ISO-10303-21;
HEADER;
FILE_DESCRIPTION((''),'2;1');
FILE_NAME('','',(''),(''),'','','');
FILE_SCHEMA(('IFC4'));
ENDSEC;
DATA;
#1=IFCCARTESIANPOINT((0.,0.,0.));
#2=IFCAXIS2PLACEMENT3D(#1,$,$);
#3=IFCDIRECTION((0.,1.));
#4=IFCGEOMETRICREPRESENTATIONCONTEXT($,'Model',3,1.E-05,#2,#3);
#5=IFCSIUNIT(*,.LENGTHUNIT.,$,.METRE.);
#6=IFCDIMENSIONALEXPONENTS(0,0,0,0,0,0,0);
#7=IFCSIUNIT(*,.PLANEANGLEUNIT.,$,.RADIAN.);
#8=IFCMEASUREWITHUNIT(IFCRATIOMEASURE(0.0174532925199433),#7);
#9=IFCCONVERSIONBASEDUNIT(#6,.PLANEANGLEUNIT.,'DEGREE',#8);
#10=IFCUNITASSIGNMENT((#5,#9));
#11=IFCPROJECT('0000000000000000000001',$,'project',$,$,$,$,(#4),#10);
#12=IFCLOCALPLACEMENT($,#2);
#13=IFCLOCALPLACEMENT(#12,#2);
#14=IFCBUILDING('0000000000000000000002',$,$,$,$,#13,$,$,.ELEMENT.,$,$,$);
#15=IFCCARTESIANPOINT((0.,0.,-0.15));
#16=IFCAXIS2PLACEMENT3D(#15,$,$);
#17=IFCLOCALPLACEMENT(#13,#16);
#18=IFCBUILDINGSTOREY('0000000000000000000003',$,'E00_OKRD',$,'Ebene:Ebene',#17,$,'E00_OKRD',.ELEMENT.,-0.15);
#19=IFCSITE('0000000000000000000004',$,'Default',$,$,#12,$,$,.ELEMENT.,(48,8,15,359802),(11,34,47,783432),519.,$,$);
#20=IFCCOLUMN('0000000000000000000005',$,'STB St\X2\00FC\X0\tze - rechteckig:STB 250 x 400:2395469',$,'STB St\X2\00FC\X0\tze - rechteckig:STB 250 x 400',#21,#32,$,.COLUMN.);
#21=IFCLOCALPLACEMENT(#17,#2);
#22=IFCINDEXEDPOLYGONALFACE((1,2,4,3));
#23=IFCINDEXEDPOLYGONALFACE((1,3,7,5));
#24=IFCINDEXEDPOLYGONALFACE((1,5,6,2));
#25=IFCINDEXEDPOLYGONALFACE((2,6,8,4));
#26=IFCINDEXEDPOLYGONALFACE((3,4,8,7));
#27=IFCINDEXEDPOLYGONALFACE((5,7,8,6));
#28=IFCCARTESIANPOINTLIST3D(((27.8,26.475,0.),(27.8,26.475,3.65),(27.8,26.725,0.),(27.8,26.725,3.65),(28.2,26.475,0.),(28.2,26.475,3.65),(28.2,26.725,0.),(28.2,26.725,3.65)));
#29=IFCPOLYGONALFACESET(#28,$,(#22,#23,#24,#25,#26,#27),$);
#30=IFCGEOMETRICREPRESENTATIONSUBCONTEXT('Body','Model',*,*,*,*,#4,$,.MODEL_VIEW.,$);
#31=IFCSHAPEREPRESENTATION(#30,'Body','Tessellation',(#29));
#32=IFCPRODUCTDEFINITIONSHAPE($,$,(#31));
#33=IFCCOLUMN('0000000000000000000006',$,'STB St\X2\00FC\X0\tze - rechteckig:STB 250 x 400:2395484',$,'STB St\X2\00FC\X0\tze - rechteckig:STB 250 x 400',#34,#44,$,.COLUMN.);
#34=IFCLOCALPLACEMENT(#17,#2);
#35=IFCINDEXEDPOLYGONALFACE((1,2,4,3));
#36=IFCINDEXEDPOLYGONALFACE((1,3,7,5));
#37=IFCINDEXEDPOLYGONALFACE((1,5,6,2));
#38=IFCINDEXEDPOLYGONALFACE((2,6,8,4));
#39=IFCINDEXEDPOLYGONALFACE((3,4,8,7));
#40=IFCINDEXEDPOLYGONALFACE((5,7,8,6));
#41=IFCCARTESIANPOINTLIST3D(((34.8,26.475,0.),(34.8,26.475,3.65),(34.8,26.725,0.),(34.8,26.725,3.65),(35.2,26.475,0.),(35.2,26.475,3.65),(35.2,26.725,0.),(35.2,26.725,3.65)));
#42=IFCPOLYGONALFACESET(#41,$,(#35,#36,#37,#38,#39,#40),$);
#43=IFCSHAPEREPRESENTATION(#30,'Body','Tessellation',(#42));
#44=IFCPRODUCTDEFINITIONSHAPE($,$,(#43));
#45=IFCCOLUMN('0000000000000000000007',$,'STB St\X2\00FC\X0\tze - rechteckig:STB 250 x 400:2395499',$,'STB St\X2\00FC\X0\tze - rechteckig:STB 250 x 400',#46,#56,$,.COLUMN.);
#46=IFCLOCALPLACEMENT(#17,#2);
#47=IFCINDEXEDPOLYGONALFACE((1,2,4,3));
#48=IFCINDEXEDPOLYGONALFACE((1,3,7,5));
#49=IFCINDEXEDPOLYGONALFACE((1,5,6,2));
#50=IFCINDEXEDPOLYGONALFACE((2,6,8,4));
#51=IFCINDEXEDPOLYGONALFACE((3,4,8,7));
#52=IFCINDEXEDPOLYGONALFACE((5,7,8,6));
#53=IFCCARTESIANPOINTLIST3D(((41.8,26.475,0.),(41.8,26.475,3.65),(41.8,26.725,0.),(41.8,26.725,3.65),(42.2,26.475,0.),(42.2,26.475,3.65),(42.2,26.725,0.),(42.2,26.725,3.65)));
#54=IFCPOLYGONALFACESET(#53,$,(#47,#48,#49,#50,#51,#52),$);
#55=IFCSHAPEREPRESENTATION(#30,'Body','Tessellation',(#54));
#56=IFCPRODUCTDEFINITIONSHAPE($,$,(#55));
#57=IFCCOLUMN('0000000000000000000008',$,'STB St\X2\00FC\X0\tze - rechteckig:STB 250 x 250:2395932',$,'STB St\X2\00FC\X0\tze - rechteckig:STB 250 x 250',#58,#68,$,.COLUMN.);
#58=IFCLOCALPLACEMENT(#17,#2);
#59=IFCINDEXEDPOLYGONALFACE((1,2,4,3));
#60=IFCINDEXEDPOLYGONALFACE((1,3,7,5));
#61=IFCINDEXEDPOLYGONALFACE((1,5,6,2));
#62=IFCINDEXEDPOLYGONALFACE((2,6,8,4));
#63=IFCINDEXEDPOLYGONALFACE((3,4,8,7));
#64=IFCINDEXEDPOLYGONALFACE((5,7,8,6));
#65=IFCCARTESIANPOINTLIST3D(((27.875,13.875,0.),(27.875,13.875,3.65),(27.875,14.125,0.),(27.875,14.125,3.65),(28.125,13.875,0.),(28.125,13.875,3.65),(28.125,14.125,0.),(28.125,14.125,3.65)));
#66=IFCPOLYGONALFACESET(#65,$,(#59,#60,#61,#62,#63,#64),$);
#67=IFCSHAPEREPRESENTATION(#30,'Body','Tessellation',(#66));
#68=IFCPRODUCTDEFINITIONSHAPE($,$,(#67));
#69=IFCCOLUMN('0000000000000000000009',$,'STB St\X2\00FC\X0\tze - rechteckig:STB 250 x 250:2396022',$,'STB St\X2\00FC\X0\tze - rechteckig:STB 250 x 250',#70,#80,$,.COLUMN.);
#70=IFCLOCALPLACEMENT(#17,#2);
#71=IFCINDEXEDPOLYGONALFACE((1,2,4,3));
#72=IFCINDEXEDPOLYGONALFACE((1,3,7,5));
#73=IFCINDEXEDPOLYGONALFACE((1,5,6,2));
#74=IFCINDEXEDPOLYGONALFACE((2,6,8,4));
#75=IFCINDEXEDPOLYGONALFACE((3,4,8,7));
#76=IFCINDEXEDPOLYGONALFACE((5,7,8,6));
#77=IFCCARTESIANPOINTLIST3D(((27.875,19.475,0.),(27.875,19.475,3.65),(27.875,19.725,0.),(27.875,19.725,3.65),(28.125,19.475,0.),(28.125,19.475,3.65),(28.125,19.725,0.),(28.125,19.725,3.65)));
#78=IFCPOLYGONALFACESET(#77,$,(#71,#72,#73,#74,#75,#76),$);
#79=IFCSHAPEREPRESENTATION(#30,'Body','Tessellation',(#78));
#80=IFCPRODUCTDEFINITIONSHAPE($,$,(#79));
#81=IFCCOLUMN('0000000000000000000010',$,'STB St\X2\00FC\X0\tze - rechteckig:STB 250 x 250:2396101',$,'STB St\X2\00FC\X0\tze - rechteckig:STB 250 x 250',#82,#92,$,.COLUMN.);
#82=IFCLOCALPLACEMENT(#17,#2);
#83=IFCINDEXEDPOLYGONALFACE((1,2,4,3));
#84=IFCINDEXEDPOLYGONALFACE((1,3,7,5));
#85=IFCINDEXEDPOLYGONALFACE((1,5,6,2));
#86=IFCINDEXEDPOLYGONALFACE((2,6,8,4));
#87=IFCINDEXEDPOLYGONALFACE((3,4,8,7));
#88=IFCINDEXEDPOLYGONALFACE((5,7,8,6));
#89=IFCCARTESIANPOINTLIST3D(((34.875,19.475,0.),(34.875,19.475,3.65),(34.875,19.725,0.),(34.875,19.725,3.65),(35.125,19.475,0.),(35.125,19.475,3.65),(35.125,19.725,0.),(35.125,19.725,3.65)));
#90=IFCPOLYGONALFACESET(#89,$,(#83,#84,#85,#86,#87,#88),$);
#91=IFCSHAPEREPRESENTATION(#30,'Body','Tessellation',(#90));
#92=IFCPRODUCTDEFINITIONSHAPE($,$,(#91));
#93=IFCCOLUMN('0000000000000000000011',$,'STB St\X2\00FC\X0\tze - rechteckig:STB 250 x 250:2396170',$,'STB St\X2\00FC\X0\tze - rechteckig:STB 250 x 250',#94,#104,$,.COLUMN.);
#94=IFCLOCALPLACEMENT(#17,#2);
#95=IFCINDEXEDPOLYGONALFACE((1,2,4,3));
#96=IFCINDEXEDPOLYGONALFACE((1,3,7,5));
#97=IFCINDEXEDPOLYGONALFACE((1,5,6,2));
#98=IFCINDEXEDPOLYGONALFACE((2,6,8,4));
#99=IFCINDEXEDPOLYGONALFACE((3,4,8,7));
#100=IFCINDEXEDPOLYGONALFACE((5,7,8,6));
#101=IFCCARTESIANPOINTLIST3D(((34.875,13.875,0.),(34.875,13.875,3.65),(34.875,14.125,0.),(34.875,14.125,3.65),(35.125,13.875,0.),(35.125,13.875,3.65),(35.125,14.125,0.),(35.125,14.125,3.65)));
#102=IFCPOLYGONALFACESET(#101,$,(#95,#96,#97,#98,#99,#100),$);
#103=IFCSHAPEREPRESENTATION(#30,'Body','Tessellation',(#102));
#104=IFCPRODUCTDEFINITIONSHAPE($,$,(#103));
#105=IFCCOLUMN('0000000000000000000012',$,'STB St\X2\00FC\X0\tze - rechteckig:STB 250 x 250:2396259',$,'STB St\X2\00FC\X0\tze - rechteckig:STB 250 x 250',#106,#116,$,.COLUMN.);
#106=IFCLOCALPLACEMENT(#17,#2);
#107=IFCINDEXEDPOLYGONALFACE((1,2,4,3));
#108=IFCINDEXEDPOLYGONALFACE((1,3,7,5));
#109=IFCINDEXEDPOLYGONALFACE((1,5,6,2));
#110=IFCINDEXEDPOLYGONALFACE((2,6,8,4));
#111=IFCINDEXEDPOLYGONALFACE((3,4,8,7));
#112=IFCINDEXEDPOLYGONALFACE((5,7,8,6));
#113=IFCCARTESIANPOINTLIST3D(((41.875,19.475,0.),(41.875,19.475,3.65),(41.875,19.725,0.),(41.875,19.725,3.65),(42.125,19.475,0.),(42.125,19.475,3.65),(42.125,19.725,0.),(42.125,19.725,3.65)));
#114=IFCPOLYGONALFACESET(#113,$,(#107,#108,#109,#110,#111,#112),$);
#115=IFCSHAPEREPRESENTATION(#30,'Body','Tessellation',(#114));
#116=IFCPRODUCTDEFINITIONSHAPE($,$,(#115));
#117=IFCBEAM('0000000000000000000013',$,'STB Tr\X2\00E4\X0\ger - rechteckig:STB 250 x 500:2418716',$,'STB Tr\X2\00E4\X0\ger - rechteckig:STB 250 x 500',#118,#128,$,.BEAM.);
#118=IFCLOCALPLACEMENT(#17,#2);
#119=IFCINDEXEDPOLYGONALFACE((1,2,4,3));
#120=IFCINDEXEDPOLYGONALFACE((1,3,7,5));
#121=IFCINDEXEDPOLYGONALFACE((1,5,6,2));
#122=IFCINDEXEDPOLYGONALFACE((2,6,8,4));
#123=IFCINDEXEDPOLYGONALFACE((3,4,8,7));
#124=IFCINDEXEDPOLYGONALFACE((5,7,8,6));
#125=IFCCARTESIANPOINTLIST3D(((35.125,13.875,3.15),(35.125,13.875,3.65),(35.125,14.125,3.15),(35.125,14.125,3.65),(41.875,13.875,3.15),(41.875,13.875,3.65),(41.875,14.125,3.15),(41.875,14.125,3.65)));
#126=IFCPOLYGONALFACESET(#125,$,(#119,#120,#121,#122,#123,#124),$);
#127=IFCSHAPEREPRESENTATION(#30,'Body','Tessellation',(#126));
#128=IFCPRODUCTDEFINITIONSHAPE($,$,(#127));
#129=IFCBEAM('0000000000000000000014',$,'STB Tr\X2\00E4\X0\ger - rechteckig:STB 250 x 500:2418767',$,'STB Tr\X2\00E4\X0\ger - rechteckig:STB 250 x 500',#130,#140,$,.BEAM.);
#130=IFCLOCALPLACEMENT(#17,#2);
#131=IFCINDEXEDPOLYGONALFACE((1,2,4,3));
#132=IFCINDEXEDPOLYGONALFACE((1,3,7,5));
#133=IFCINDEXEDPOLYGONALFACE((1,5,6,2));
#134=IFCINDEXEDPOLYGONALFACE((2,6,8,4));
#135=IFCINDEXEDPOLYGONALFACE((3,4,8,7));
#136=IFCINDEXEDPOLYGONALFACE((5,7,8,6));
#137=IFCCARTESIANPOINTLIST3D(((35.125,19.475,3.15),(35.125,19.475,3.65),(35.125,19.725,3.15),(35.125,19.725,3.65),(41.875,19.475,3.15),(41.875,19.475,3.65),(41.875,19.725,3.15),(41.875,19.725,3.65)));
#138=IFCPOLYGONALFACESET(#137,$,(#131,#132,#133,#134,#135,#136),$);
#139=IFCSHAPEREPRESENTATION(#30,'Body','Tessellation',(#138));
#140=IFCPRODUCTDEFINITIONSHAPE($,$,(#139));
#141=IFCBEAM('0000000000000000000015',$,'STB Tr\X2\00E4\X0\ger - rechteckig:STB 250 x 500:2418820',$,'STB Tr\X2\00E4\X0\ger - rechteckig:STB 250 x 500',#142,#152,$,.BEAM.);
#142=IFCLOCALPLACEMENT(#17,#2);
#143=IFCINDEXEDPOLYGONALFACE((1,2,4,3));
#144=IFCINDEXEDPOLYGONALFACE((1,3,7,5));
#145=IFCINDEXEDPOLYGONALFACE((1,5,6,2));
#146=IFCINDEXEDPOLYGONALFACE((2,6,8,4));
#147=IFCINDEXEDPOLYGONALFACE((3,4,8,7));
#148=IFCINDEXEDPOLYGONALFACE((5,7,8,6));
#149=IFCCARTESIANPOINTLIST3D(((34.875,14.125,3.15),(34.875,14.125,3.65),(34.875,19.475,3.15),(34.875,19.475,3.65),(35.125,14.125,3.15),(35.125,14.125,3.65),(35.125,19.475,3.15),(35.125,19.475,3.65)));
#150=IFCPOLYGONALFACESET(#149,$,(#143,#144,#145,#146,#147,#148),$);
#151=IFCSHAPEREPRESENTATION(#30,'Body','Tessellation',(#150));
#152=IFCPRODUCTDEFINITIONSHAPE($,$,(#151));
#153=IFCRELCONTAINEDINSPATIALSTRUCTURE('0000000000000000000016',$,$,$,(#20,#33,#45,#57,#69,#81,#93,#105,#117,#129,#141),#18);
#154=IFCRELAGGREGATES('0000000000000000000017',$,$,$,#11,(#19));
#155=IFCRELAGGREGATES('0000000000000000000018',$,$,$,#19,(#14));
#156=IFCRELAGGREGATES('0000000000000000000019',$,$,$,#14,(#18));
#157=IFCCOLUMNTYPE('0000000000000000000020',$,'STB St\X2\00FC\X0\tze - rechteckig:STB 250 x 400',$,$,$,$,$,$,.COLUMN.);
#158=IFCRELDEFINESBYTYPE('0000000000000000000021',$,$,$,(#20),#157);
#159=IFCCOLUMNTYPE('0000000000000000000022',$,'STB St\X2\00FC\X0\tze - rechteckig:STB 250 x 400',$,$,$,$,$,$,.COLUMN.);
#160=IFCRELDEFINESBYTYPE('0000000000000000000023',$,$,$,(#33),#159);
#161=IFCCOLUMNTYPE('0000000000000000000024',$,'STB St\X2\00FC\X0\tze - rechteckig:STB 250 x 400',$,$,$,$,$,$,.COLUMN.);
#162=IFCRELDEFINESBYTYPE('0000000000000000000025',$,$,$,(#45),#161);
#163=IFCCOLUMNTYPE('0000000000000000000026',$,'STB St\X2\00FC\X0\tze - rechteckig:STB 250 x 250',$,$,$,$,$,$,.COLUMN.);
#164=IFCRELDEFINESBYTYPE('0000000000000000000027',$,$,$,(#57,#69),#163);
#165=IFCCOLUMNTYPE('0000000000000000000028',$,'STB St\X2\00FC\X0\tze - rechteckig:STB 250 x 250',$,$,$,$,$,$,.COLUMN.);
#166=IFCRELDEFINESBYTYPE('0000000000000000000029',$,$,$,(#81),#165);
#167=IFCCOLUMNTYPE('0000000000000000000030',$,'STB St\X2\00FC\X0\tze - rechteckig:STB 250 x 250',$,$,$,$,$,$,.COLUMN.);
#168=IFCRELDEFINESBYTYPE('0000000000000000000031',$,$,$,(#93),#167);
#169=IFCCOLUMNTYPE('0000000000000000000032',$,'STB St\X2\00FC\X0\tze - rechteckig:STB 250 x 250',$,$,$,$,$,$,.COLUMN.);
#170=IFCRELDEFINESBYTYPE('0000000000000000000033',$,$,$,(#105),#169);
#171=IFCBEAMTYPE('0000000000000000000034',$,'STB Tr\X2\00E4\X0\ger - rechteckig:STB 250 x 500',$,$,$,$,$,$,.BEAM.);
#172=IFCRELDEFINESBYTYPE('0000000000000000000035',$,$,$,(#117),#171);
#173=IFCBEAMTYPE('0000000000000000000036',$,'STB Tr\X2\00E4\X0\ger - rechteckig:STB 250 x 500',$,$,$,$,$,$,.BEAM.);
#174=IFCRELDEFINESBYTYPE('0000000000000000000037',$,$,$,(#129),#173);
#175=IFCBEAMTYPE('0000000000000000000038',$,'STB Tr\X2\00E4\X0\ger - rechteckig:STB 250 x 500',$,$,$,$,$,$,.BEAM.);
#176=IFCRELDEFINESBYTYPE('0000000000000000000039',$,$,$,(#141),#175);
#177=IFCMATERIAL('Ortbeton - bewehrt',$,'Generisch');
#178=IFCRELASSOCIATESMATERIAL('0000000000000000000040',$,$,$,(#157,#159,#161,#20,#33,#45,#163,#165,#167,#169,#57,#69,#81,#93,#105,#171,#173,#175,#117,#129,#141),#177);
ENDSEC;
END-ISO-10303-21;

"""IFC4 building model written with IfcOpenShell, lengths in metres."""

from ifc_helpers import new_model, entity, si_unit, converted_unit, direction, frame, frame_2d, origin, origin_2d_with_axis, place, context, subcontext, project, spatial, rectangle, extrude, source, transform, mapped, material, material_profile, profile_set, profile_usage, type_object, type_shapes, element, save


model = new_model("IFC4")

# Units and contexts
model_context = context("Model", 3, precision=1e-05, world=origin(), true_north=direction((0.0, 1.0)))
body_context = subcontext(model_context, "Body", "Model", "MODEL_VIEW")
ifc_project = project(units=[si_unit("LENGTHUNIT", "METRE"), converted_unit("PLANEANGLEUNIT", "DEGREE", entity("IfcRatioMeasure", 0.0174532925199433), si_unit("PLANEANGLEUNIT", "RADIAN"), dimensions=[0, 0, 0, 0, 0, 0, 0])], contexts=[model_context])

# Site, building, storey
site_placement = place(None, frame((0.0, 0.0, 0.0)))
site = spatial("IfcSite", under=ifc_project, at=site_placement, Name="Default", CompositionType="ELEMENT", RefLatitude=(48, 8, 15, 359802), RefLongitude=(11, 34, 47, 783432), RefElevation=519.0)
building_placement = place(site_placement, origin())
building = spatial("IfcBuilding", under=site, at=building_placement, CompositionType="ELEMENT")
storey_placement = place(building_placement, frame((0.0, 0.0, -0.15)))
storey = spatial("IfcBuildingStorey", under=building, at=storey_placement, Name="E00_OKRD", ObjectType="Ebene:Ebene", LongName="E00_OKRD", CompositionType="ELEMENT", Elevation=-0.15)

# Columns
ifc_material_1 = material(Name="Ortbeton - bewehrt", Category="Generisch")
ifc_material_profile_1 = material_profile(ifc_material_1, rectangle(XDim=0.4, YDim=0.25, at=frame_2d((0.0, 0.0), x_axis=(1.0, 0.0))), Name="STB 250 x 400")
ifc_profile_set_1 = profile_set([ifc_material_profile_1], Name="STB 250 x 400")
ifc_profile_usage_1 = profile_usage(ifc_profile_set_1)
column_type_1 = type_object("IfcColumnType", Name="STB Stütze - rechteckig:STB 250 x 400", PredefinedType="COLUMN", material=ifc_profile_set_1)
shared_shape_1 = source(origin(), body_context, "Body", "SweptSolid", [
    extrude(rectangle(XDim=0.4, YDim=0.25, at=frame_2d((0.0, 0.0), x_axis=(1.0, 0.0))), frame((0.2, 0.125, 0.0), z_axis=(0.0, 0.0, 1.0), x_axis=(-1.0, 0.0, 0.0)), (0.0, 0.0, 1.0), 3.65),
])
type_shapes(column_type_1, [shared_shape_1])
column_1_placement = place(storey_placement, frame((27.8, 26.475, 0.0)))
element("IfcColumn", 1, at=column_1_placement, inside=storey, type_object=column_type_1, material=ifc_profile_usage_1, Name="STB Stütze - rechteckig:STB 250 x 400:2395469", ObjectType="STB Stütze - rechteckig:STB 250 x 400", PredefinedType="COLUMN", context=body_context, shape_type="MappedRepresentation", body=[
    mapped(shared_shape_1, transform((0.0, 0.0, 0.0), scale=1.0)),
])
ifc_profile_usage_2 = profile_usage(ifc_profile_set_1)
column_type_2 = type_object("IfcColumnType", Name="STB Stütze - rechteckig:STB 250 x 400", PredefinedType="COLUMN", material=ifc_profile_set_1)
shared_shape_2 = source(origin(), body_context, "Body", "SweptSolid", [
    extrude(rectangle(XDim=0.4, YDim=0.25, at=frame_2d((0.0, 0.0), x_axis=(1.0, 0.0))), frame((0.2, 0.125, 0.0), z_axis=(0.0, 0.0, 1.0), x_axis=(-1.0, 0.0, 0.0)), (0.0, 0.0, 1.0), 3.65),
])
type_shapes(column_type_2, [shared_shape_2])
column_2_placement = place(storey_placement, frame((34.8, 26.475, 0.0)))
element("IfcColumn", 2, at=column_2_placement, inside=storey, type_object=column_type_2, material=ifc_profile_usage_2, Name="STB Stütze - rechteckig:STB 250 x 400:2395484", ObjectType="STB Stütze - rechteckig:STB 250 x 400", PredefinedType="COLUMN", context=body_context, shape_type="MappedRepresentation", body=[
    mapped(shared_shape_2, transform((0.0, 0.0, 0.0), scale=1.0)),
])
ifc_profile_usage_3 = profile_usage(ifc_profile_set_1)
column_type_3 = type_object("IfcColumnType", Name="STB Stütze - rechteckig:STB 250 x 400", PredefinedType="COLUMN", material=ifc_profile_set_1)
shared_shape_3 = source(origin(), body_context, "Body", "SweptSolid", [
    extrude(rectangle(XDim=0.4, YDim=0.25, at=origin_2d_with_axis()), frame((0.2, 0.125, 0.0), z_axis=(0.0, 0.0, 1.0), x_axis=(-1.0, 0.0, 0.0)), (0.0, 0.0, 1.0), 3.65),
])
type_shapes(column_type_3, [shared_shape_3])
column_3_placement = place(storey_placement, frame((41.8, 26.475, 0.0)))
element("IfcColumn", 3, at=column_3_placement, inside=storey, type_object=column_type_3, material=ifc_profile_usage_3, Name="STB Stütze - rechteckig:STB 250 x 400:2395499", ObjectType="STB Stütze - rechteckig:STB 250 x 400", PredefinedType="COLUMN", context=body_context, shape_type="MappedRepresentation", body=[
    mapped(shared_shape_3, transform((0.0, 0.0, 0.0), scale=1.0)),
])
ifc_material_profile_2 = material_profile(ifc_material_1, rectangle(XDim=0.25, YDim=0.25, at=origin_2d_with_axis()), Name="STB 250 x 250")
ifc_profile_set_2 = profile_set([ifc_material_profile_2], Name="STB 250 x 250")
ifc_profile_usage_4 = profile_usage(ifc_profile_set_2)
column_type_4 = type_object("IfcColumnType", Name="STB Stütze - rechteckig:STB 250 x 250", PredefinedType="COLUMN", material=ifc_profile_set_2)
shared_shape_4 = source(origin(), body_context, "Body", "SweptSolid", [
    extrude(rectangle(XDim=0.25, YDim=0.25, at=origin_2d_with_axis()), frame((0.0, 0.0, -0.15), z_axis=(0.0, 0.0, 1.0), x_axis=(-1.0, 0.0, 0.0)), (0.0, 0.0, 1.0), 3.65),
])
type_shapes(column_type_4, [shared_shape_4])
column_4_placement = place(storey_placement, frame((28.0, 14.0, 0.15)))
element("IfcColumn", 4, at=column_4_placement, inside=storey, type_object=column_type_4, material=ifc_profile_usage_4, Name="STB Stütze - rechteckig:STB 250 x 250:2395932", ObjectType="STB Stütze - rechteckig:STB 250 x 250", PredefinedType="COLUMN", context=body_context, shape_type="MappedRepresentation", body=[
    mapped(shared_shape_4, transform((0.0, 0.0, 0.0), scale=1.0)),
])
ifc_profile_usage_5 = profile_usage(ifc_profile_set_2)
column_5_placement = place(storey_placement, frame((28.0, 19.6, 0.15)))
element("IfcColumn", 5, at=column_5_placement, inside=storey, type_object=column_type_4, material=ifc_profile_usage_5, Name="STB Stütze - rechteckig:STB 250 x 250:2396022", ObjectType="STB Stütze - rechteckig:STB 250 x 250", PredefinedType="COLUMN", context=body_context, shape_type="MappedRepresentation", body=[
    mapped(shared_shape_4, transform((0.0, 0.0, 0.0), scale=1.0)),
])
ifc_profile_usage_6 = profile_usage(ifc_profile_set_2)
column_type_5 = type_object("IfcColumnType", Name="STB Stütze - rechteckig:STB 250 x 250", PredefinedType="COLUMN", material=ifc_profile_set_2)
shared_shape_5 = source(origin(), body_context, "Body", "SweptSolid", [
    extrude(rectangle(XDim=0.25, YDim=0.25, at=frame_2d((0.0, 0.0), x_axis=(1.0, 0.0))), frame((0.125, 0.125, 0.0), z_axis=(0.0, 0.0, 1.0), x_axis=(-1.0, 0.0, 0.0)), (0.0, 0.0, 1.0), 3.65),
])
type_shapes(column_type_5, [shared_shape_5])
column_6_placement = place(storey_placement, frame((34.875, 19.475, 0.0)))
element("IfcColumn", 6, at=column_6_placement, inside=storey, type_object=column_type_5, material=ifc_profile_usage_6, Name="STB Stütze - rechteckig:STB 250 x 250:2396101", ObjectType="STB Stütze - rechteckig:STB 250 x 250", PredefinedType="COLUMN", context=body_context, shape_type="MappedRepresentation", body=[
    mapped(shared_shape_5, transform((0.0, 0.0, 0.0), scale=1.0)),
])
ifc_profile_usage_7 = profile_usage(ifc_profile_set_2)
column_type_6 = type_object("IfcColumnType", Name="STB Stütze - rechteckig:STB 250 x 250", PredefinedType="COLUMN", material=ifc_profile_set_2)
shared_shape_6 = source(origin(), body_context, "Body", "SweptSolid", [
    extrude(rectangle(XDim=0.25, YDim=0.25, at=frame_2d((0.0, 0.0), x_axis=(1.0, 0.0))), frame((0.125, 0.125, 0.0), z_axis=(0.0, 0.0, 1.0), x_axis=(-1.0, 0.0, 0.0)), (0.0, 0.0, 1.0), 3.65),
])
type_shapes(column_type_6, [shared_shape_6])
column_7_placement = place(storey_placement, frame((34.875, 13.875, 0.0)))
element("IfcColumn", 7, at=column_7_placement, inside=storey, type_object=column_type_6, material=ifc_profile_usage_7, Name="STB Stütze - rechteckig:STB 250 x 250:2396170", ObjectType="STB Stütze - rechteckig:STB 250 x 250", PredefinedType="COLUMN", context=body_context, shape_type="MappedRepresentation", body=[
    mapped(shared_shape_6, transform((0.0, 0.0, 0.0), scale=1.0)),
])
ifc_profile_usage_8 = profile_usage(ifc_profile_set_2)
column_type_7 = type_object("IfcColumnType", Name="STB Stütze - rechteckig:STB 250 x 250", PredefinedType="COLUMN", material=ifc_profile_set_2)
shared_shape_7 = source(origin(), body_context, "Body", "SweptSolid", [
    extrude(rectangle(XDim=0.25, YDim=0.25, at=frame_2d((0.0, 0.0), x_axis=(1.0, 0.0))), frame((0.125, 0.125, 0.0), z_axis=(0.0, 0.0, 1.0), x_axis=(-1.0, 0.0, 0.0)), (0.0, 0.0, 1.0), 3.65),
])
type_shapes(column_type_7, [shared_shape_7])
column_8_placement = place(storey_placement, frame((41.875, 19.475, 0.0)))
element("IfcColumn", 8, at=column_8_placement, inside=storey, type_object=column_type_7, material=ifc_profile_usage_8, Name="STB Stütze - rechteckig:STB 250 x 250:2396259", ObjectType="STB Stütze - rechteckig:STB 250 x 250", PredefinedType="COLUMN", context=body_context, shape_type="MappedRepresentation", body=[
    mapped(shared_shape_7, transform((0.0, 0.0, 0.0), scale=1.0)),
])

# Beams
ifc_material_profile_3 = material_profile(ifc_material_1, rectangle(XDim=0.5, YDim=0.25, at=frame_2d((0.0, 0.0), x_axis=(1.0, 0.0))), Name="STB 250 x 500")
ifc_profile_set_3 = profile_set([ifc_material_profile_3], Name="STB 250 x 500")
ifc_profile_usage_9 = profile_usage(ifc_profile_set_3, cardinal=8)
beam_type_1 = type_object("IfcBeamType", Name="STB Träger - rechteckig:STB 250 x 500", PredefinedType="BEAM", material=ifc_profile_set_3)
shared_shape_8 = source(origin(), body_context, "Body", "SweptSolid", [
    extrude(rectangle(XDim=0.5, YDim=0.25, at=origin_2d_with_axis()), frame((0.0, 0.125, 0.25), z_axis=(1.0, 0.0, 0.0), x_axis=(0.0, 0.0, -1.0)), (0.0, 0.0, 1.0), 6.75),
])
type_shapes(beam_type_1, [shared_shape_8])
beam_1_placement = place(storey_placement, frame((35.125, 13.875, 3.15)))
element("IfcBeam", 9, at=beam_1_placement, inside=storey, type_object=beam_type_1, material=ifc_profile_usage_9, Name="STB Träger - rechteckig:STB 250 x 500:2418716", ObjectType="STB Träger - rechteckig:STB 250 x 500", PredefinedType="BEAM", context=body_context, shape_type="MappedRepresentation", body=[
    mapped(shared_shape_8, transform((0.0, 0.0, 0.0), scale=1.0)),
])
ifc_profile_usage_10 = profile_usage(ifc_profile_set_3, cardinal=8)
beam_type_2 = type_object("IfcBeamType", Name="STB Träger - rechteckig:STB 250 x 500", PredefinedType="BEAM", material=ifc_profile_set_3)
shared_shape_9 = source(origin(), body_context, "Body", "SweptSolid", [
    extrude(rectangle(XDim=0.5, YDim=0.25, at=frame_2d((0.0, 0.0), x_axis=(1.0, 0.0))), frame((0.0, 0.125, 0.25), z_axis=(1.0, 0.0, 0.0), x_axis=(0.0, 0.0, -1.0)), (0.0, 0.0, 1.0), 6.75),
])
type_shapes(beam_type_2, [shared_shape_9])
beam_2_placement = place(storey_placement, frame((35.125, 19.475, 3.15)))
element("IfcBeam", 10, at=beam_2_placement, inside=storey, type_object=beam_type_2, material=ifc_profile_usage_10, Name="STB Träger - rechteckig:STB 250 x 500:2418767", ObjectType="STB Träger - rechteckig:STB 250 x 500", PredefinedType="BEAM", context=body_context, shape_type="MappedRepresentation", body=[
    mapped(shared_shape_9, transform((0.0, 0.0, 0.0), scale=1.0)),
])
ifc_profile_usage_11 = profile_usage(ifc_profile_set_3, cardinal=8)
beam_type_3 = type_object("IfcBeamType", Name="STB Träger - rechteckig:STB 250 x 500", PredefinedType="BEAM", material=ifc_profile_set_3)
shared_shape_10 = source(origin(), body_context, "Body", "SweptSolid", [
    extrude(rectangle(XDim=0.5, YDim=5.35, at=frame_2d((0.0, 0.0), x_axis=(0.0, 1.0))), frame((0.0, 2.675, 0.25), z_axis=(1.0, 0.0, 0.0), x_axis=(0.0, -1.0, 0.0)), (0.0, 0.0, 1.0), 0.25),
])
type_shapes(beam_type_3, [shared_shape_10])
beam_3_placement = place(storey_placement, frame((34.875, 14.125, 3.15)))
element("IfcBeam", 11, at=beam_3_placement, inside=storey, type_object=beam_type_3, material=ifc_profile_usage_11, Name="STB Träger - rechteckig:STB 250 x 500:2418820", ObjectType="STB Träger - rechteckig:STB 250 x 500", PredefinedType="BEAM", context=body_context, shape_type="MappedRepresentation", body=[
    mapped(shared_shape_10, transform((0.0, 0.0, 0.0), scale=1.0)),
])

save(model, "model.ifc")
